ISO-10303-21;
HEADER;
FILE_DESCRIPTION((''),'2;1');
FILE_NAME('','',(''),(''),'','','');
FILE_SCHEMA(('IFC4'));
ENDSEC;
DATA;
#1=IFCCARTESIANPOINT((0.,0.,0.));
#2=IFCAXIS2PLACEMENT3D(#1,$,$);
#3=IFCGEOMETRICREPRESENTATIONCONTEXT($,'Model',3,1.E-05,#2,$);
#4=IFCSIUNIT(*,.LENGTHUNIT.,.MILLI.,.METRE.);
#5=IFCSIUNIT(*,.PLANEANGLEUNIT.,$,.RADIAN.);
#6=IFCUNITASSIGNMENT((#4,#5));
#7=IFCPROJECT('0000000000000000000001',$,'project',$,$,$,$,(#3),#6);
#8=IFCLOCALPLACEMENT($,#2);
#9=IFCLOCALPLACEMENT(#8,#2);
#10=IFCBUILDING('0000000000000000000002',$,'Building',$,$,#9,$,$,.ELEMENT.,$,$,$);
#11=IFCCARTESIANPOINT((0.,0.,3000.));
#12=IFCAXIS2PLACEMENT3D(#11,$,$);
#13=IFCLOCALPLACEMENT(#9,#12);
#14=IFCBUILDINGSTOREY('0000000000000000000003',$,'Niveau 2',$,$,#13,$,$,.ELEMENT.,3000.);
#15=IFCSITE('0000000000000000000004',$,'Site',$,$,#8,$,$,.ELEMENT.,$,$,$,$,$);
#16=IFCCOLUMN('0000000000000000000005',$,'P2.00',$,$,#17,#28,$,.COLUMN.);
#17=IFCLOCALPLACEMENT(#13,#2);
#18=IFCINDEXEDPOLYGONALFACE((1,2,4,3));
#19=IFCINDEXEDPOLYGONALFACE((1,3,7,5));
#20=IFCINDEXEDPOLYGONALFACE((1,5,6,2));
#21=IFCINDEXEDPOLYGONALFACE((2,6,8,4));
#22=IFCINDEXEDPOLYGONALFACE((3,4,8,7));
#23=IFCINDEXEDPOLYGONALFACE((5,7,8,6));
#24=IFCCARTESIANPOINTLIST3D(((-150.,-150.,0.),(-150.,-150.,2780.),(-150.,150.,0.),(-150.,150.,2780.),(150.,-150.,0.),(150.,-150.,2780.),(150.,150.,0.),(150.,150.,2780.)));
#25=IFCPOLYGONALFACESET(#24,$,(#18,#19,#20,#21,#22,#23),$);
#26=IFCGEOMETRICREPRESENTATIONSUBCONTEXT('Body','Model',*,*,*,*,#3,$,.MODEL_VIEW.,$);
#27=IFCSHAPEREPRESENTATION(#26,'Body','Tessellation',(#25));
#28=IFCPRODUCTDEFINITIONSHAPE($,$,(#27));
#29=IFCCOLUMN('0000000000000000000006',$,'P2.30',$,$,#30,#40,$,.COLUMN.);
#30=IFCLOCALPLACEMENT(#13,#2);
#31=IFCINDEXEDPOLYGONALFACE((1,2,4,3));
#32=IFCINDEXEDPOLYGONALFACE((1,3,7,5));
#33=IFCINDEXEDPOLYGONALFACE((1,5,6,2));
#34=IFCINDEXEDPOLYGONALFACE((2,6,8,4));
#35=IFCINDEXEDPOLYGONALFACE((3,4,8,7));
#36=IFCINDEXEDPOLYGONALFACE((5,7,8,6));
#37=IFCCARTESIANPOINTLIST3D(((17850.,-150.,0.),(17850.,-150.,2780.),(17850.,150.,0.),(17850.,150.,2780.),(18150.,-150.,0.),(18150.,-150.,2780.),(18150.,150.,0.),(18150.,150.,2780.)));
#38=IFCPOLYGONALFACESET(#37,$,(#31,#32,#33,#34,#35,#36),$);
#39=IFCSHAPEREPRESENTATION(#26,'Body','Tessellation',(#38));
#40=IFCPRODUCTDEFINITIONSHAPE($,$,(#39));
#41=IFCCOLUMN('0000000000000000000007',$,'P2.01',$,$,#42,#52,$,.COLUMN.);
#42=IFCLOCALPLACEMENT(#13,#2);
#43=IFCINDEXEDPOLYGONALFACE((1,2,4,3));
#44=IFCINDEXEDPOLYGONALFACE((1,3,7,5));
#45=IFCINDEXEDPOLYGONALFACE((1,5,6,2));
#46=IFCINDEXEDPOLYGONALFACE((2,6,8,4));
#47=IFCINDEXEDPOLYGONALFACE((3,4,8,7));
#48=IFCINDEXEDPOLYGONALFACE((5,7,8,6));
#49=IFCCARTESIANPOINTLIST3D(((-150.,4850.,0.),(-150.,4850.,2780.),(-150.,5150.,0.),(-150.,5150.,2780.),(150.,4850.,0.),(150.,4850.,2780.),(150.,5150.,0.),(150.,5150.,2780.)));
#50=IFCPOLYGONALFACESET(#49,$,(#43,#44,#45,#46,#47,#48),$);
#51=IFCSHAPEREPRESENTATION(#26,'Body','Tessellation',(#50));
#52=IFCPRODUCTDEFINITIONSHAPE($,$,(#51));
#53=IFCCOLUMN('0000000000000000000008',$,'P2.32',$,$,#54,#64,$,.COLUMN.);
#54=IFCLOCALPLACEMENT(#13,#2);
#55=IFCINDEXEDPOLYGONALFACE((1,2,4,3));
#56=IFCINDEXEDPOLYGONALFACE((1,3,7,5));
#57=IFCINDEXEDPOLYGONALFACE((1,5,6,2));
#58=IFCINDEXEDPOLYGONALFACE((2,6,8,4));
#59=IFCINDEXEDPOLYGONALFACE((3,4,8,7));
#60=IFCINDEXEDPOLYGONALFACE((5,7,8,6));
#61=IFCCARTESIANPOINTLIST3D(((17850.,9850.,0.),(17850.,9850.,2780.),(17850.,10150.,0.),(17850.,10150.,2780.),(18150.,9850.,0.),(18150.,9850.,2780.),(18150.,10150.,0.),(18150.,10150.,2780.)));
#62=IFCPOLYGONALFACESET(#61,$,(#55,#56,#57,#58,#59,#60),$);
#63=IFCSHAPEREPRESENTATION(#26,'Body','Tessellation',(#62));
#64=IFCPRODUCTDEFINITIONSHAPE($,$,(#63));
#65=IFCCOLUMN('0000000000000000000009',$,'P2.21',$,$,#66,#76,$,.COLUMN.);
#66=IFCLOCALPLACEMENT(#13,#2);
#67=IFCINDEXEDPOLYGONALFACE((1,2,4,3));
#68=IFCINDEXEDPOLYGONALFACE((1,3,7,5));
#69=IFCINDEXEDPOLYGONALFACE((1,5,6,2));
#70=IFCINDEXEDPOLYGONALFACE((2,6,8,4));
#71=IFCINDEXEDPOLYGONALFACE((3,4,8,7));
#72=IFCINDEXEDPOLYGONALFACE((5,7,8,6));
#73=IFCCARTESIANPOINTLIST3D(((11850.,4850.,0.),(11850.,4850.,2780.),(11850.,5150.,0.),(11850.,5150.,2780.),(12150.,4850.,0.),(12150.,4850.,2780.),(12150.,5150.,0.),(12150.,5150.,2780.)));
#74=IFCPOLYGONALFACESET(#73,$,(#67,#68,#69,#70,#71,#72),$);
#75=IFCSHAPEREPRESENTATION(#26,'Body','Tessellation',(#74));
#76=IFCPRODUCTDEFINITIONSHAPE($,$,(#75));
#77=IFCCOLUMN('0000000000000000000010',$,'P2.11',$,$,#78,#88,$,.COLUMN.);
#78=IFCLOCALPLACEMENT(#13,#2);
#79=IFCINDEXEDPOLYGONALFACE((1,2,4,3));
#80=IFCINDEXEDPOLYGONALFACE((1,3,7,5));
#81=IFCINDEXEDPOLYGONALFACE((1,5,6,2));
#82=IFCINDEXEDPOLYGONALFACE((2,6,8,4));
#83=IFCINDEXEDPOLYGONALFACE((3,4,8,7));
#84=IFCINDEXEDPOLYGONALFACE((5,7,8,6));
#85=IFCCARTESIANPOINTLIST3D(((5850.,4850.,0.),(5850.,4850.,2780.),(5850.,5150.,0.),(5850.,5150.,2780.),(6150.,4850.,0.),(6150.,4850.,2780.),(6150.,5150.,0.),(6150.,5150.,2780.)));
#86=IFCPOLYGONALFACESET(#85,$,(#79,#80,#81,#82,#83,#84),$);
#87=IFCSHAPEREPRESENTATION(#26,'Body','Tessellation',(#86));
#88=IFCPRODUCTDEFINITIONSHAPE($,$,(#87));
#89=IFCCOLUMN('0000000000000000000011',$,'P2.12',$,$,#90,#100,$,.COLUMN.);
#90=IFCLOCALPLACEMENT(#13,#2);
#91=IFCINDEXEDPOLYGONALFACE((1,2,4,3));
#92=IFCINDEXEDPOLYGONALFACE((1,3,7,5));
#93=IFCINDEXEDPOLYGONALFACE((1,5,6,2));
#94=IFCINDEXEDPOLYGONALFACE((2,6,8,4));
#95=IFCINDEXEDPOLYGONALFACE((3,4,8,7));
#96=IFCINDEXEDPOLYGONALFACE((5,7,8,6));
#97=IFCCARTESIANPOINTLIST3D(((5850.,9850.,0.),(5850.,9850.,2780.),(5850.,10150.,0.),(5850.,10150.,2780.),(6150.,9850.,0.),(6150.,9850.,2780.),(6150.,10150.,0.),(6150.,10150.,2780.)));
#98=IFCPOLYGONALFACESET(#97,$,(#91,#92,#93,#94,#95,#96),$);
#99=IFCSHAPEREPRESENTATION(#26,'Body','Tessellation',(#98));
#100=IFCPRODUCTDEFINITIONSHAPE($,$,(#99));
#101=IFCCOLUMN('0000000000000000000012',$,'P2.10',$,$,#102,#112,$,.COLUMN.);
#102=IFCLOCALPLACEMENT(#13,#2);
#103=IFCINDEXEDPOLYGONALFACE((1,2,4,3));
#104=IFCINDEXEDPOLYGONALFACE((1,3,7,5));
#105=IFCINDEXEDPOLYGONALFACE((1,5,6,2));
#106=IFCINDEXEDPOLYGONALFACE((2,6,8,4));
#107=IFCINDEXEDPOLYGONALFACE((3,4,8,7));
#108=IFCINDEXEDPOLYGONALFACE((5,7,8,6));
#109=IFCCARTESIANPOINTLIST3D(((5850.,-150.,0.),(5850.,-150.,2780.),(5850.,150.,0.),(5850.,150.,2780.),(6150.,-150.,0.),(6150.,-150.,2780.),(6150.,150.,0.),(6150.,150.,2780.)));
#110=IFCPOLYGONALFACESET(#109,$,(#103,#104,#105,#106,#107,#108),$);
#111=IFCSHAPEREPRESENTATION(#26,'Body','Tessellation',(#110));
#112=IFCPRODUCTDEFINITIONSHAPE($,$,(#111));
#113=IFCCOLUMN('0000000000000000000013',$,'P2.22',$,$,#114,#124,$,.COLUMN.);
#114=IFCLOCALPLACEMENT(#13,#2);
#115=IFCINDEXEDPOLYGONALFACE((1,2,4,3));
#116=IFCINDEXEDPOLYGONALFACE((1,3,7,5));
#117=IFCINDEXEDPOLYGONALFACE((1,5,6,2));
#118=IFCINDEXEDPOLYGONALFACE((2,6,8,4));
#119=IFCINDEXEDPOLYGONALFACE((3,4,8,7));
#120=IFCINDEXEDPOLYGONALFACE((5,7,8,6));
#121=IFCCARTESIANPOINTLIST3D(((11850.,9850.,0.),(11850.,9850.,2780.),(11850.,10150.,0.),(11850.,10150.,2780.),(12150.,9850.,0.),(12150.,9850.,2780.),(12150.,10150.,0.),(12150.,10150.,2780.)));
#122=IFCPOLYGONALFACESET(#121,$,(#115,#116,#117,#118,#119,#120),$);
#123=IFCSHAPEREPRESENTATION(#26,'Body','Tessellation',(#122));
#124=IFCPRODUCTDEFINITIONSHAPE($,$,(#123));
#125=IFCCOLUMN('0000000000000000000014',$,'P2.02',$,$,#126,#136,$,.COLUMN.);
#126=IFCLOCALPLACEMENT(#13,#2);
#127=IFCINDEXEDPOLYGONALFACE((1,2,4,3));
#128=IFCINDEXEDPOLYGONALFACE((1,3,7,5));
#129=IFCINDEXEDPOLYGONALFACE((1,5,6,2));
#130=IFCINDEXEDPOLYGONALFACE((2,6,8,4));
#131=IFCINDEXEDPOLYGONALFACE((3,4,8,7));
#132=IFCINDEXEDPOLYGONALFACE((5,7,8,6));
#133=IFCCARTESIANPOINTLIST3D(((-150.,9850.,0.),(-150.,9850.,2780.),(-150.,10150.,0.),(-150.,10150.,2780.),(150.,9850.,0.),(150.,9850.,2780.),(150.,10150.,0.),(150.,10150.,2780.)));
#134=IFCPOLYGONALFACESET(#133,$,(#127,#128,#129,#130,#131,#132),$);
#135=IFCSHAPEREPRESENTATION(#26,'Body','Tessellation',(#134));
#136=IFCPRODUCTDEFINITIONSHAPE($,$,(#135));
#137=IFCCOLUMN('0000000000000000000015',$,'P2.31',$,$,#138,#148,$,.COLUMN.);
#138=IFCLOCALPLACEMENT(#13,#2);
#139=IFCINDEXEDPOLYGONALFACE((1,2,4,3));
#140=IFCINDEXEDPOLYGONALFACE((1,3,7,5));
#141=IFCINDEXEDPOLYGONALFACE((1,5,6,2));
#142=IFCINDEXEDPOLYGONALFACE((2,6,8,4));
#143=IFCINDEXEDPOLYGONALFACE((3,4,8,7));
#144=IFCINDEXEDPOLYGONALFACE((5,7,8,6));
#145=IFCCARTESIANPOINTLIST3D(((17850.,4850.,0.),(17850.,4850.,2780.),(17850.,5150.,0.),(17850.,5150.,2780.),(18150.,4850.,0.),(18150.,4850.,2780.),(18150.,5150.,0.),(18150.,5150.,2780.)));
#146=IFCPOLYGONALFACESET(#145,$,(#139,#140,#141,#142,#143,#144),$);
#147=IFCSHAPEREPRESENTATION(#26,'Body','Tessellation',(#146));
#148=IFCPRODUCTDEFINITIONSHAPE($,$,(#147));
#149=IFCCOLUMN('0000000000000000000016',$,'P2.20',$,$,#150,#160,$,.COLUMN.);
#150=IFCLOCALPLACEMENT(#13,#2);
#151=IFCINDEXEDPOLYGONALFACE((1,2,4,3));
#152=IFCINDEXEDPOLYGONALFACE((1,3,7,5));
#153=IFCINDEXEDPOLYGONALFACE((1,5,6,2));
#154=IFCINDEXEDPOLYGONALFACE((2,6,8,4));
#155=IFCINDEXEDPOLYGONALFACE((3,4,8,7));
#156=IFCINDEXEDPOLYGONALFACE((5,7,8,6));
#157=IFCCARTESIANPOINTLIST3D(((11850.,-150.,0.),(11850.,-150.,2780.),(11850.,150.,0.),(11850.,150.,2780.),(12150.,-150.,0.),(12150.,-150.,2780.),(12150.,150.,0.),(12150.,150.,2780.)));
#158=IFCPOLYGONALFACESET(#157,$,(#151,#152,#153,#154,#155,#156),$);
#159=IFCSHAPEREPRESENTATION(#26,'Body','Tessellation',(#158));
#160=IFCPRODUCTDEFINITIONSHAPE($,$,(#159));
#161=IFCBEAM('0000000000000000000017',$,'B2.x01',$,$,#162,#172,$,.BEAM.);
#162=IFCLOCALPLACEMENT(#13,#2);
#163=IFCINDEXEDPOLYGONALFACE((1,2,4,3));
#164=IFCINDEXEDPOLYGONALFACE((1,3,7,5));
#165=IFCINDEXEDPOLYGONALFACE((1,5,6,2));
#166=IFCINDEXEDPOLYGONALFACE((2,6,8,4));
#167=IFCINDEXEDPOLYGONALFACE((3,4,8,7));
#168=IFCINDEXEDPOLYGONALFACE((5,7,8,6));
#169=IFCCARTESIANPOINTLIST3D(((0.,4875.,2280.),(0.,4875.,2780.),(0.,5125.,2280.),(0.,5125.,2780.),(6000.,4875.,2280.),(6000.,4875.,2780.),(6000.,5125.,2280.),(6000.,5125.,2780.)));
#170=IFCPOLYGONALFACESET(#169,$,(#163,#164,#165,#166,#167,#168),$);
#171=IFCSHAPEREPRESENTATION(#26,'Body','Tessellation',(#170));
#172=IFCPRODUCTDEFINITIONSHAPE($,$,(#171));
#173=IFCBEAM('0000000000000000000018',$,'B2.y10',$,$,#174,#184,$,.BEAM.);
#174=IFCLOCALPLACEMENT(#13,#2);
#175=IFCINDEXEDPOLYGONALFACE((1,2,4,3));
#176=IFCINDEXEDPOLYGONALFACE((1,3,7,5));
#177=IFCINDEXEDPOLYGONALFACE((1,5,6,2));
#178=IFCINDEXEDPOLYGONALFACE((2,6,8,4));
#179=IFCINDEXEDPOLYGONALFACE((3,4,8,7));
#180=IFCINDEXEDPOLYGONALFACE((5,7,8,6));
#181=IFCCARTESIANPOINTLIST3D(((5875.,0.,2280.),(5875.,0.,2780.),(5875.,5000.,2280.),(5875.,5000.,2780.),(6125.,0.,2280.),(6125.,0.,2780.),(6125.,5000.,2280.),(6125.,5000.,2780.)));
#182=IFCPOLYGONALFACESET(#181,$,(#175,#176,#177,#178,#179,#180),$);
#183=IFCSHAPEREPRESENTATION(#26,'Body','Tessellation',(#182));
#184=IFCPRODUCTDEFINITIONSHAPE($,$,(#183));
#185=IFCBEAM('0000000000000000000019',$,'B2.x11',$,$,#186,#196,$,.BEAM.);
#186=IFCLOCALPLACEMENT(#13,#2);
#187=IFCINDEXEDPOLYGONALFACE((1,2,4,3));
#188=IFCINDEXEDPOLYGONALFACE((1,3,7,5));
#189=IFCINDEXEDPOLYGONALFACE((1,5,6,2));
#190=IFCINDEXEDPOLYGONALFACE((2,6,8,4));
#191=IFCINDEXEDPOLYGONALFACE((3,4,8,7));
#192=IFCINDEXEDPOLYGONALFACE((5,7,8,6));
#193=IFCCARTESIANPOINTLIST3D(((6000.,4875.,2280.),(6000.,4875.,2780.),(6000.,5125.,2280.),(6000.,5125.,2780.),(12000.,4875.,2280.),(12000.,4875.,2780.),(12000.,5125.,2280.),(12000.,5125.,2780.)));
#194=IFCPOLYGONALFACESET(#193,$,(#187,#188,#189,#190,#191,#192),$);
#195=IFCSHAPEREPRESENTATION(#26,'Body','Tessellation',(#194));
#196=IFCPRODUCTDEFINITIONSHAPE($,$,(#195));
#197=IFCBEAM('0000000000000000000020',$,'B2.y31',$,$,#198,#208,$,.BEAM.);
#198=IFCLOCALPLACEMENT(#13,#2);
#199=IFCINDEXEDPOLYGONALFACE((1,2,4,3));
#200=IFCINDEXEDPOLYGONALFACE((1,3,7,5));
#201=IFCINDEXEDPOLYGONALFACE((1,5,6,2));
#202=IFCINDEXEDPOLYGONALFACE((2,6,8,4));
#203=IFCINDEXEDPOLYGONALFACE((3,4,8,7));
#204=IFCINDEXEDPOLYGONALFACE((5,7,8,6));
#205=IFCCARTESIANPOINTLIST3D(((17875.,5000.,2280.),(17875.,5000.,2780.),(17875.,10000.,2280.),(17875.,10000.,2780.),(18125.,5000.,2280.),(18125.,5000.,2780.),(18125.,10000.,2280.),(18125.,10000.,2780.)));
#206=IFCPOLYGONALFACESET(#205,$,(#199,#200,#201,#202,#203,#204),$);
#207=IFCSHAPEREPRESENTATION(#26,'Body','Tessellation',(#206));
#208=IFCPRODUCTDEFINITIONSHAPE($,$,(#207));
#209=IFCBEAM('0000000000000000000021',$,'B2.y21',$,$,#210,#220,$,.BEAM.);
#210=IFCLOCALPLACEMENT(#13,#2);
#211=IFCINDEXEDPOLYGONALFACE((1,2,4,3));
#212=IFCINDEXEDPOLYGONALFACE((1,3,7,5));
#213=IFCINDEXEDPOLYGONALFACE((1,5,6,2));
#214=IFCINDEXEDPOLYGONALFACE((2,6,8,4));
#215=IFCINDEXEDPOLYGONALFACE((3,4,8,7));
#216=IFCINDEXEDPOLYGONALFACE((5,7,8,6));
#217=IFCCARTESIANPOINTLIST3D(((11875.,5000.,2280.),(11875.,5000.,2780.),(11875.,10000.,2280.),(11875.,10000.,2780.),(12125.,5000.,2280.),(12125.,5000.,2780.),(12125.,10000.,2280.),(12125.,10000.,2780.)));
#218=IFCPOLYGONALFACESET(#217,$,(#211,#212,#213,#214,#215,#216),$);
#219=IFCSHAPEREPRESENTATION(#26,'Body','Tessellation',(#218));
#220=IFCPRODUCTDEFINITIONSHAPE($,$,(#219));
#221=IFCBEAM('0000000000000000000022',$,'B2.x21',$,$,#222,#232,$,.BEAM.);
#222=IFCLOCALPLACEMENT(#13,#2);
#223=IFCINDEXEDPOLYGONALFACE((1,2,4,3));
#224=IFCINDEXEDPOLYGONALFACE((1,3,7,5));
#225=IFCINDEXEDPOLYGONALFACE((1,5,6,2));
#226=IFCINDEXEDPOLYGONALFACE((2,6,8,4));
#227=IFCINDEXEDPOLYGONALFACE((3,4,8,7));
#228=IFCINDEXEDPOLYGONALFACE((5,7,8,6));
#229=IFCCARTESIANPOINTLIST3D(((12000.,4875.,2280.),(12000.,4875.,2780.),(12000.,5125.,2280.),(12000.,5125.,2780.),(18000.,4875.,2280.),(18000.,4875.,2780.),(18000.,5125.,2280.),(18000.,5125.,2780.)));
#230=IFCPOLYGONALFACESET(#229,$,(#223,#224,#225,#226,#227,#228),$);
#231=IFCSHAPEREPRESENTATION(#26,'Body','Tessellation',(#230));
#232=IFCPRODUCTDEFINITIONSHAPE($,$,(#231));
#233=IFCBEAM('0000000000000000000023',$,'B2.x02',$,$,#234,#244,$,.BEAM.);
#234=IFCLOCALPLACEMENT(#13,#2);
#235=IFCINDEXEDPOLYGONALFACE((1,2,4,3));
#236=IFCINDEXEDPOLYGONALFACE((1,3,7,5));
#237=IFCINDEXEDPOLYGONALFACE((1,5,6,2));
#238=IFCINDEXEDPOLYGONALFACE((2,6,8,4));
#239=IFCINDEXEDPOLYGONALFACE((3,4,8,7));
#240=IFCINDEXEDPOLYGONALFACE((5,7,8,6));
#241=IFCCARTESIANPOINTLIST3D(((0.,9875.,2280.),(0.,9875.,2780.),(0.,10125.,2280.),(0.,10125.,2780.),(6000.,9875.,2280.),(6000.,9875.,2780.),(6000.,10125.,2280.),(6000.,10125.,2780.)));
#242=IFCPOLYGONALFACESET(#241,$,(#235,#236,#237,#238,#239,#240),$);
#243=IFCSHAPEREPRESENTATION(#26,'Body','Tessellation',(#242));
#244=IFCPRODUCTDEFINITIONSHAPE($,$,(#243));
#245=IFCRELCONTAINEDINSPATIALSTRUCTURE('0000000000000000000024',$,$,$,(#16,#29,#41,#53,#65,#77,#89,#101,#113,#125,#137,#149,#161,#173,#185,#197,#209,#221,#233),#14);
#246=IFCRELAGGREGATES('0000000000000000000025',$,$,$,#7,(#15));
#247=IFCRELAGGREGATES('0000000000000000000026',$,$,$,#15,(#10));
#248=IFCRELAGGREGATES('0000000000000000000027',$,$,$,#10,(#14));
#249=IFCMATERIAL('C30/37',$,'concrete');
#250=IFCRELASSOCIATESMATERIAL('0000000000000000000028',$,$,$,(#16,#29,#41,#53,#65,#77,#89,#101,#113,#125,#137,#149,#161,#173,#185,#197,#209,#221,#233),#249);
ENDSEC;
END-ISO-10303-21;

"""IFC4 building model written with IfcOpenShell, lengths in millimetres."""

from ifc_helpers import new_model, si_unit, frame, origin, place, context, subcontext, project, spatial, rectangle, extrude, material, element, save


model = new_model("IFC4")

# Units and contexts
model_context = context("Model", 3, precision=1e-05, world=origin())
body_context = subcontext(model_context, "Body", "Model", "MODEL_VIEW")
ifc_project = project(units=[si_unit("LENGTHUNIT", "METRE", prefix="MILLI"), si_unit("PLANEANGLEUNIT", "RADIAN")], contexts=[model_context])

# Site, building, storey
site_placement = place(None, origin())
site = spatial("IfcSite", under=ifc_project, at=site_placement, Name="Site", CompositionType="ELEMENT")
building_placement = place(site_placement, origin())
building = spatial("IfcBuilding", under=site, at=building_placement, Name="Building", CompositionType="ELEMENT")
storey_placement = place(building_placement, frame((0.0, 0.0, 3000.0)))
storey = spatial("IfcBuildingStorey", under=building, at=storey_placement, Name="Niveau 2", CompositionType="ELEMENT", Elevation=3000.0)

# Columns
ifc_material = material(Name="C30/37", Category="concrete")
for number, where, z_axis, x_axis, name in (
    (1, (0.0, 0.0, 0.0), (0.0, 0.0, 1.0), (1.0, 0.0, 0.0), "P2.00"),
    (2, (18000.0, 0.0, 0.0), (0.0, 0.0, 1.0), (1.0, 0.0, 0.0), "P2.30"),
    (3, (0.0, 5000.0, 0.0), (0.0, 0.0, 1.0), (1.0, 0.0, 0.0), "P2.01"),
    (4, (18000.0, 10000.0, 0.0), (0.0, 0.0, 1.0), (1.0, 0.0, 0.0), "P2.32"),
    (5, (12000.0, 5000.0, 0.0), (0.0, 0.0, 1.0), (1.0, 0.0, 0.0), "P2.21"),
    (6, (6000.0, 5000.0, 0.0), (0.0, 0.0, 1.0), (1.0, 0.0, 0.0), "P2.11"),
    (7, (6000.0, 10000.0, 0.0), (0.0, 0.0, 1.0), (1.0, 0.0, 0.0), "P2.12"),
    (8, (6000.0, 0.0, 0.0), (0.0, 0.0, 1.0), (1.0, 0.0, 0.0), "P2.10"),
    (9, (12000.0, 10000.0, 0.0), (0.0, 0.0, 1.0), (1.0, 0.0, 0.0), "P2.22"),
    (10, (0.0, 10000.0, 0.0), (0.0, 0.0, 1.0), (1.0, 0.0, 0.0), "P2.02"),
    (11, (18000.0, 5000.0, 0.0), (0.0, 0.0, 1.0), (1.0, 0.0, 0.0), "P2.31"),
    (12, (12000.0, 0.0, 0.0), (0.0, 0.0, 1.0), (1.0, 0.0, 0.0), "P2.20"),
):
    element("IfcColumn", number, at=place(storey_placement, frame(where, z_axis=z_axis, x_axis=x_axis)), inside=storey, material=ifc_material, Name=name, PredefinedType="COLUMN", context=body_context, shape_type="SweptSolid", body=[
        extrude(rectangle(XDim=300.0, YDim=300.0), origin(), (0.0, 0.0, 1.0), 2780.0),
    ])

# Beams
beam_1_placement = place(storey_placement, frame((0.0, 5000.0, 2530.0), z_axis=(1.0, 0.0, 0.0), x_axis=(0.0, 1.0, 0.0)))
element("IfcBeam", 13, at=beam_1_placement, inside=storey, material=ifc_material, Name="B2.x01", PredefinedType="BEAM", context=body_context, shape_type="SweptSolid", body=[
    extrude(rectangle(XDim=250.0, YDim=500.0), origin(), (0.0, 0.0, 1.0), 6000.0),
])
beam_2_placement = place(storey_placement, frame((6000.0, 0.0, 2530.0), z_axis=(0.0, 1.0, 0.0), x_axis=(-1.0, 0.0, 0.0)))
element("IfcBeam", 14, at=beam_2_placement, inside=storey, material=ifc_material, Name="B2.y10", PredefinedType="BEAM", context=body_context, shape_type="SweptSolid", body=[
    extrude(rectangle(XDim=250.0, YDim=500.0), origin(), (0.0, 0.0, 1.0), 5000.0),
])
beam_3_placement = place(storey_placement, frame((6000.0, 5000.0, 2530.0), z_axis=(1.0, 0.0, 0.0), x_axis=(0.0, 1.0, 0.0)))
element("IfcBeam", 15, at=beam_3_placement, inside=storey, material=ifc_material, Name="B2.x11", PredefinedType="BEAM", context=body_context, shape_type="SweptSolid", body=[
    extrude(rectangle(XDim=250.0, YDim=500.0), origin(), (0.0, 0.0, 1.0), 6000.0),
])
for number, where, z_axis, x_axis, name in (
    (16, (18000.0, 5000.0, 2530.0), (0.0, 1.0, 0.0), (-1.0, 0.0, 0.0), "B2.y31"),
    (17, (12000.0, 5000.0, 2530.0), (0.0, 1.0, 0.0), (-1.0, 0.0, 0.0), "B2.y21"),
):
    element("IfcBeam", number, at=place(storey_placement, frame(where, z_axis=z_axis, x_axis=x_axis)), inside=storey, material=ifc_material, Name=name, PredefinedType="BEAM", context=body_context, shape_type="SweptSolid", body=[
        extrude(rectangle(XDim=250.0, YDim=500.0), origin(), (0.0, 0.0, 1.0), 5000.0),
    ])
for number, where, z_axis, x_axis, name in (
    (18, (12000.0, 5000.0, 2530.0), (1.0, 0.0, 0.0), (0.0, 1.0, 0.0), "B2.x21"),
    (19, (0.0, 10000.0, 2530.0), (1.0, 0.0, 0.0), (0.0, 1.0, 0.0), "B2.x02"),
):
    element("IfcBeam", number, at=place(storey_placement, frame(where, z_axis=z_axis, x_axis=x_axis)), inside=storey, material=ifc_material, Name=name, PredefinedType="BEAM", context=body_context, shape_type="SweptSolid", body=[
        extrude(rectangle(XDim=250.0, YDim=500.0), origin(), (0.0, 0.0, 1.0), 6000.0),
    ])

save(model, "model.ifc")
